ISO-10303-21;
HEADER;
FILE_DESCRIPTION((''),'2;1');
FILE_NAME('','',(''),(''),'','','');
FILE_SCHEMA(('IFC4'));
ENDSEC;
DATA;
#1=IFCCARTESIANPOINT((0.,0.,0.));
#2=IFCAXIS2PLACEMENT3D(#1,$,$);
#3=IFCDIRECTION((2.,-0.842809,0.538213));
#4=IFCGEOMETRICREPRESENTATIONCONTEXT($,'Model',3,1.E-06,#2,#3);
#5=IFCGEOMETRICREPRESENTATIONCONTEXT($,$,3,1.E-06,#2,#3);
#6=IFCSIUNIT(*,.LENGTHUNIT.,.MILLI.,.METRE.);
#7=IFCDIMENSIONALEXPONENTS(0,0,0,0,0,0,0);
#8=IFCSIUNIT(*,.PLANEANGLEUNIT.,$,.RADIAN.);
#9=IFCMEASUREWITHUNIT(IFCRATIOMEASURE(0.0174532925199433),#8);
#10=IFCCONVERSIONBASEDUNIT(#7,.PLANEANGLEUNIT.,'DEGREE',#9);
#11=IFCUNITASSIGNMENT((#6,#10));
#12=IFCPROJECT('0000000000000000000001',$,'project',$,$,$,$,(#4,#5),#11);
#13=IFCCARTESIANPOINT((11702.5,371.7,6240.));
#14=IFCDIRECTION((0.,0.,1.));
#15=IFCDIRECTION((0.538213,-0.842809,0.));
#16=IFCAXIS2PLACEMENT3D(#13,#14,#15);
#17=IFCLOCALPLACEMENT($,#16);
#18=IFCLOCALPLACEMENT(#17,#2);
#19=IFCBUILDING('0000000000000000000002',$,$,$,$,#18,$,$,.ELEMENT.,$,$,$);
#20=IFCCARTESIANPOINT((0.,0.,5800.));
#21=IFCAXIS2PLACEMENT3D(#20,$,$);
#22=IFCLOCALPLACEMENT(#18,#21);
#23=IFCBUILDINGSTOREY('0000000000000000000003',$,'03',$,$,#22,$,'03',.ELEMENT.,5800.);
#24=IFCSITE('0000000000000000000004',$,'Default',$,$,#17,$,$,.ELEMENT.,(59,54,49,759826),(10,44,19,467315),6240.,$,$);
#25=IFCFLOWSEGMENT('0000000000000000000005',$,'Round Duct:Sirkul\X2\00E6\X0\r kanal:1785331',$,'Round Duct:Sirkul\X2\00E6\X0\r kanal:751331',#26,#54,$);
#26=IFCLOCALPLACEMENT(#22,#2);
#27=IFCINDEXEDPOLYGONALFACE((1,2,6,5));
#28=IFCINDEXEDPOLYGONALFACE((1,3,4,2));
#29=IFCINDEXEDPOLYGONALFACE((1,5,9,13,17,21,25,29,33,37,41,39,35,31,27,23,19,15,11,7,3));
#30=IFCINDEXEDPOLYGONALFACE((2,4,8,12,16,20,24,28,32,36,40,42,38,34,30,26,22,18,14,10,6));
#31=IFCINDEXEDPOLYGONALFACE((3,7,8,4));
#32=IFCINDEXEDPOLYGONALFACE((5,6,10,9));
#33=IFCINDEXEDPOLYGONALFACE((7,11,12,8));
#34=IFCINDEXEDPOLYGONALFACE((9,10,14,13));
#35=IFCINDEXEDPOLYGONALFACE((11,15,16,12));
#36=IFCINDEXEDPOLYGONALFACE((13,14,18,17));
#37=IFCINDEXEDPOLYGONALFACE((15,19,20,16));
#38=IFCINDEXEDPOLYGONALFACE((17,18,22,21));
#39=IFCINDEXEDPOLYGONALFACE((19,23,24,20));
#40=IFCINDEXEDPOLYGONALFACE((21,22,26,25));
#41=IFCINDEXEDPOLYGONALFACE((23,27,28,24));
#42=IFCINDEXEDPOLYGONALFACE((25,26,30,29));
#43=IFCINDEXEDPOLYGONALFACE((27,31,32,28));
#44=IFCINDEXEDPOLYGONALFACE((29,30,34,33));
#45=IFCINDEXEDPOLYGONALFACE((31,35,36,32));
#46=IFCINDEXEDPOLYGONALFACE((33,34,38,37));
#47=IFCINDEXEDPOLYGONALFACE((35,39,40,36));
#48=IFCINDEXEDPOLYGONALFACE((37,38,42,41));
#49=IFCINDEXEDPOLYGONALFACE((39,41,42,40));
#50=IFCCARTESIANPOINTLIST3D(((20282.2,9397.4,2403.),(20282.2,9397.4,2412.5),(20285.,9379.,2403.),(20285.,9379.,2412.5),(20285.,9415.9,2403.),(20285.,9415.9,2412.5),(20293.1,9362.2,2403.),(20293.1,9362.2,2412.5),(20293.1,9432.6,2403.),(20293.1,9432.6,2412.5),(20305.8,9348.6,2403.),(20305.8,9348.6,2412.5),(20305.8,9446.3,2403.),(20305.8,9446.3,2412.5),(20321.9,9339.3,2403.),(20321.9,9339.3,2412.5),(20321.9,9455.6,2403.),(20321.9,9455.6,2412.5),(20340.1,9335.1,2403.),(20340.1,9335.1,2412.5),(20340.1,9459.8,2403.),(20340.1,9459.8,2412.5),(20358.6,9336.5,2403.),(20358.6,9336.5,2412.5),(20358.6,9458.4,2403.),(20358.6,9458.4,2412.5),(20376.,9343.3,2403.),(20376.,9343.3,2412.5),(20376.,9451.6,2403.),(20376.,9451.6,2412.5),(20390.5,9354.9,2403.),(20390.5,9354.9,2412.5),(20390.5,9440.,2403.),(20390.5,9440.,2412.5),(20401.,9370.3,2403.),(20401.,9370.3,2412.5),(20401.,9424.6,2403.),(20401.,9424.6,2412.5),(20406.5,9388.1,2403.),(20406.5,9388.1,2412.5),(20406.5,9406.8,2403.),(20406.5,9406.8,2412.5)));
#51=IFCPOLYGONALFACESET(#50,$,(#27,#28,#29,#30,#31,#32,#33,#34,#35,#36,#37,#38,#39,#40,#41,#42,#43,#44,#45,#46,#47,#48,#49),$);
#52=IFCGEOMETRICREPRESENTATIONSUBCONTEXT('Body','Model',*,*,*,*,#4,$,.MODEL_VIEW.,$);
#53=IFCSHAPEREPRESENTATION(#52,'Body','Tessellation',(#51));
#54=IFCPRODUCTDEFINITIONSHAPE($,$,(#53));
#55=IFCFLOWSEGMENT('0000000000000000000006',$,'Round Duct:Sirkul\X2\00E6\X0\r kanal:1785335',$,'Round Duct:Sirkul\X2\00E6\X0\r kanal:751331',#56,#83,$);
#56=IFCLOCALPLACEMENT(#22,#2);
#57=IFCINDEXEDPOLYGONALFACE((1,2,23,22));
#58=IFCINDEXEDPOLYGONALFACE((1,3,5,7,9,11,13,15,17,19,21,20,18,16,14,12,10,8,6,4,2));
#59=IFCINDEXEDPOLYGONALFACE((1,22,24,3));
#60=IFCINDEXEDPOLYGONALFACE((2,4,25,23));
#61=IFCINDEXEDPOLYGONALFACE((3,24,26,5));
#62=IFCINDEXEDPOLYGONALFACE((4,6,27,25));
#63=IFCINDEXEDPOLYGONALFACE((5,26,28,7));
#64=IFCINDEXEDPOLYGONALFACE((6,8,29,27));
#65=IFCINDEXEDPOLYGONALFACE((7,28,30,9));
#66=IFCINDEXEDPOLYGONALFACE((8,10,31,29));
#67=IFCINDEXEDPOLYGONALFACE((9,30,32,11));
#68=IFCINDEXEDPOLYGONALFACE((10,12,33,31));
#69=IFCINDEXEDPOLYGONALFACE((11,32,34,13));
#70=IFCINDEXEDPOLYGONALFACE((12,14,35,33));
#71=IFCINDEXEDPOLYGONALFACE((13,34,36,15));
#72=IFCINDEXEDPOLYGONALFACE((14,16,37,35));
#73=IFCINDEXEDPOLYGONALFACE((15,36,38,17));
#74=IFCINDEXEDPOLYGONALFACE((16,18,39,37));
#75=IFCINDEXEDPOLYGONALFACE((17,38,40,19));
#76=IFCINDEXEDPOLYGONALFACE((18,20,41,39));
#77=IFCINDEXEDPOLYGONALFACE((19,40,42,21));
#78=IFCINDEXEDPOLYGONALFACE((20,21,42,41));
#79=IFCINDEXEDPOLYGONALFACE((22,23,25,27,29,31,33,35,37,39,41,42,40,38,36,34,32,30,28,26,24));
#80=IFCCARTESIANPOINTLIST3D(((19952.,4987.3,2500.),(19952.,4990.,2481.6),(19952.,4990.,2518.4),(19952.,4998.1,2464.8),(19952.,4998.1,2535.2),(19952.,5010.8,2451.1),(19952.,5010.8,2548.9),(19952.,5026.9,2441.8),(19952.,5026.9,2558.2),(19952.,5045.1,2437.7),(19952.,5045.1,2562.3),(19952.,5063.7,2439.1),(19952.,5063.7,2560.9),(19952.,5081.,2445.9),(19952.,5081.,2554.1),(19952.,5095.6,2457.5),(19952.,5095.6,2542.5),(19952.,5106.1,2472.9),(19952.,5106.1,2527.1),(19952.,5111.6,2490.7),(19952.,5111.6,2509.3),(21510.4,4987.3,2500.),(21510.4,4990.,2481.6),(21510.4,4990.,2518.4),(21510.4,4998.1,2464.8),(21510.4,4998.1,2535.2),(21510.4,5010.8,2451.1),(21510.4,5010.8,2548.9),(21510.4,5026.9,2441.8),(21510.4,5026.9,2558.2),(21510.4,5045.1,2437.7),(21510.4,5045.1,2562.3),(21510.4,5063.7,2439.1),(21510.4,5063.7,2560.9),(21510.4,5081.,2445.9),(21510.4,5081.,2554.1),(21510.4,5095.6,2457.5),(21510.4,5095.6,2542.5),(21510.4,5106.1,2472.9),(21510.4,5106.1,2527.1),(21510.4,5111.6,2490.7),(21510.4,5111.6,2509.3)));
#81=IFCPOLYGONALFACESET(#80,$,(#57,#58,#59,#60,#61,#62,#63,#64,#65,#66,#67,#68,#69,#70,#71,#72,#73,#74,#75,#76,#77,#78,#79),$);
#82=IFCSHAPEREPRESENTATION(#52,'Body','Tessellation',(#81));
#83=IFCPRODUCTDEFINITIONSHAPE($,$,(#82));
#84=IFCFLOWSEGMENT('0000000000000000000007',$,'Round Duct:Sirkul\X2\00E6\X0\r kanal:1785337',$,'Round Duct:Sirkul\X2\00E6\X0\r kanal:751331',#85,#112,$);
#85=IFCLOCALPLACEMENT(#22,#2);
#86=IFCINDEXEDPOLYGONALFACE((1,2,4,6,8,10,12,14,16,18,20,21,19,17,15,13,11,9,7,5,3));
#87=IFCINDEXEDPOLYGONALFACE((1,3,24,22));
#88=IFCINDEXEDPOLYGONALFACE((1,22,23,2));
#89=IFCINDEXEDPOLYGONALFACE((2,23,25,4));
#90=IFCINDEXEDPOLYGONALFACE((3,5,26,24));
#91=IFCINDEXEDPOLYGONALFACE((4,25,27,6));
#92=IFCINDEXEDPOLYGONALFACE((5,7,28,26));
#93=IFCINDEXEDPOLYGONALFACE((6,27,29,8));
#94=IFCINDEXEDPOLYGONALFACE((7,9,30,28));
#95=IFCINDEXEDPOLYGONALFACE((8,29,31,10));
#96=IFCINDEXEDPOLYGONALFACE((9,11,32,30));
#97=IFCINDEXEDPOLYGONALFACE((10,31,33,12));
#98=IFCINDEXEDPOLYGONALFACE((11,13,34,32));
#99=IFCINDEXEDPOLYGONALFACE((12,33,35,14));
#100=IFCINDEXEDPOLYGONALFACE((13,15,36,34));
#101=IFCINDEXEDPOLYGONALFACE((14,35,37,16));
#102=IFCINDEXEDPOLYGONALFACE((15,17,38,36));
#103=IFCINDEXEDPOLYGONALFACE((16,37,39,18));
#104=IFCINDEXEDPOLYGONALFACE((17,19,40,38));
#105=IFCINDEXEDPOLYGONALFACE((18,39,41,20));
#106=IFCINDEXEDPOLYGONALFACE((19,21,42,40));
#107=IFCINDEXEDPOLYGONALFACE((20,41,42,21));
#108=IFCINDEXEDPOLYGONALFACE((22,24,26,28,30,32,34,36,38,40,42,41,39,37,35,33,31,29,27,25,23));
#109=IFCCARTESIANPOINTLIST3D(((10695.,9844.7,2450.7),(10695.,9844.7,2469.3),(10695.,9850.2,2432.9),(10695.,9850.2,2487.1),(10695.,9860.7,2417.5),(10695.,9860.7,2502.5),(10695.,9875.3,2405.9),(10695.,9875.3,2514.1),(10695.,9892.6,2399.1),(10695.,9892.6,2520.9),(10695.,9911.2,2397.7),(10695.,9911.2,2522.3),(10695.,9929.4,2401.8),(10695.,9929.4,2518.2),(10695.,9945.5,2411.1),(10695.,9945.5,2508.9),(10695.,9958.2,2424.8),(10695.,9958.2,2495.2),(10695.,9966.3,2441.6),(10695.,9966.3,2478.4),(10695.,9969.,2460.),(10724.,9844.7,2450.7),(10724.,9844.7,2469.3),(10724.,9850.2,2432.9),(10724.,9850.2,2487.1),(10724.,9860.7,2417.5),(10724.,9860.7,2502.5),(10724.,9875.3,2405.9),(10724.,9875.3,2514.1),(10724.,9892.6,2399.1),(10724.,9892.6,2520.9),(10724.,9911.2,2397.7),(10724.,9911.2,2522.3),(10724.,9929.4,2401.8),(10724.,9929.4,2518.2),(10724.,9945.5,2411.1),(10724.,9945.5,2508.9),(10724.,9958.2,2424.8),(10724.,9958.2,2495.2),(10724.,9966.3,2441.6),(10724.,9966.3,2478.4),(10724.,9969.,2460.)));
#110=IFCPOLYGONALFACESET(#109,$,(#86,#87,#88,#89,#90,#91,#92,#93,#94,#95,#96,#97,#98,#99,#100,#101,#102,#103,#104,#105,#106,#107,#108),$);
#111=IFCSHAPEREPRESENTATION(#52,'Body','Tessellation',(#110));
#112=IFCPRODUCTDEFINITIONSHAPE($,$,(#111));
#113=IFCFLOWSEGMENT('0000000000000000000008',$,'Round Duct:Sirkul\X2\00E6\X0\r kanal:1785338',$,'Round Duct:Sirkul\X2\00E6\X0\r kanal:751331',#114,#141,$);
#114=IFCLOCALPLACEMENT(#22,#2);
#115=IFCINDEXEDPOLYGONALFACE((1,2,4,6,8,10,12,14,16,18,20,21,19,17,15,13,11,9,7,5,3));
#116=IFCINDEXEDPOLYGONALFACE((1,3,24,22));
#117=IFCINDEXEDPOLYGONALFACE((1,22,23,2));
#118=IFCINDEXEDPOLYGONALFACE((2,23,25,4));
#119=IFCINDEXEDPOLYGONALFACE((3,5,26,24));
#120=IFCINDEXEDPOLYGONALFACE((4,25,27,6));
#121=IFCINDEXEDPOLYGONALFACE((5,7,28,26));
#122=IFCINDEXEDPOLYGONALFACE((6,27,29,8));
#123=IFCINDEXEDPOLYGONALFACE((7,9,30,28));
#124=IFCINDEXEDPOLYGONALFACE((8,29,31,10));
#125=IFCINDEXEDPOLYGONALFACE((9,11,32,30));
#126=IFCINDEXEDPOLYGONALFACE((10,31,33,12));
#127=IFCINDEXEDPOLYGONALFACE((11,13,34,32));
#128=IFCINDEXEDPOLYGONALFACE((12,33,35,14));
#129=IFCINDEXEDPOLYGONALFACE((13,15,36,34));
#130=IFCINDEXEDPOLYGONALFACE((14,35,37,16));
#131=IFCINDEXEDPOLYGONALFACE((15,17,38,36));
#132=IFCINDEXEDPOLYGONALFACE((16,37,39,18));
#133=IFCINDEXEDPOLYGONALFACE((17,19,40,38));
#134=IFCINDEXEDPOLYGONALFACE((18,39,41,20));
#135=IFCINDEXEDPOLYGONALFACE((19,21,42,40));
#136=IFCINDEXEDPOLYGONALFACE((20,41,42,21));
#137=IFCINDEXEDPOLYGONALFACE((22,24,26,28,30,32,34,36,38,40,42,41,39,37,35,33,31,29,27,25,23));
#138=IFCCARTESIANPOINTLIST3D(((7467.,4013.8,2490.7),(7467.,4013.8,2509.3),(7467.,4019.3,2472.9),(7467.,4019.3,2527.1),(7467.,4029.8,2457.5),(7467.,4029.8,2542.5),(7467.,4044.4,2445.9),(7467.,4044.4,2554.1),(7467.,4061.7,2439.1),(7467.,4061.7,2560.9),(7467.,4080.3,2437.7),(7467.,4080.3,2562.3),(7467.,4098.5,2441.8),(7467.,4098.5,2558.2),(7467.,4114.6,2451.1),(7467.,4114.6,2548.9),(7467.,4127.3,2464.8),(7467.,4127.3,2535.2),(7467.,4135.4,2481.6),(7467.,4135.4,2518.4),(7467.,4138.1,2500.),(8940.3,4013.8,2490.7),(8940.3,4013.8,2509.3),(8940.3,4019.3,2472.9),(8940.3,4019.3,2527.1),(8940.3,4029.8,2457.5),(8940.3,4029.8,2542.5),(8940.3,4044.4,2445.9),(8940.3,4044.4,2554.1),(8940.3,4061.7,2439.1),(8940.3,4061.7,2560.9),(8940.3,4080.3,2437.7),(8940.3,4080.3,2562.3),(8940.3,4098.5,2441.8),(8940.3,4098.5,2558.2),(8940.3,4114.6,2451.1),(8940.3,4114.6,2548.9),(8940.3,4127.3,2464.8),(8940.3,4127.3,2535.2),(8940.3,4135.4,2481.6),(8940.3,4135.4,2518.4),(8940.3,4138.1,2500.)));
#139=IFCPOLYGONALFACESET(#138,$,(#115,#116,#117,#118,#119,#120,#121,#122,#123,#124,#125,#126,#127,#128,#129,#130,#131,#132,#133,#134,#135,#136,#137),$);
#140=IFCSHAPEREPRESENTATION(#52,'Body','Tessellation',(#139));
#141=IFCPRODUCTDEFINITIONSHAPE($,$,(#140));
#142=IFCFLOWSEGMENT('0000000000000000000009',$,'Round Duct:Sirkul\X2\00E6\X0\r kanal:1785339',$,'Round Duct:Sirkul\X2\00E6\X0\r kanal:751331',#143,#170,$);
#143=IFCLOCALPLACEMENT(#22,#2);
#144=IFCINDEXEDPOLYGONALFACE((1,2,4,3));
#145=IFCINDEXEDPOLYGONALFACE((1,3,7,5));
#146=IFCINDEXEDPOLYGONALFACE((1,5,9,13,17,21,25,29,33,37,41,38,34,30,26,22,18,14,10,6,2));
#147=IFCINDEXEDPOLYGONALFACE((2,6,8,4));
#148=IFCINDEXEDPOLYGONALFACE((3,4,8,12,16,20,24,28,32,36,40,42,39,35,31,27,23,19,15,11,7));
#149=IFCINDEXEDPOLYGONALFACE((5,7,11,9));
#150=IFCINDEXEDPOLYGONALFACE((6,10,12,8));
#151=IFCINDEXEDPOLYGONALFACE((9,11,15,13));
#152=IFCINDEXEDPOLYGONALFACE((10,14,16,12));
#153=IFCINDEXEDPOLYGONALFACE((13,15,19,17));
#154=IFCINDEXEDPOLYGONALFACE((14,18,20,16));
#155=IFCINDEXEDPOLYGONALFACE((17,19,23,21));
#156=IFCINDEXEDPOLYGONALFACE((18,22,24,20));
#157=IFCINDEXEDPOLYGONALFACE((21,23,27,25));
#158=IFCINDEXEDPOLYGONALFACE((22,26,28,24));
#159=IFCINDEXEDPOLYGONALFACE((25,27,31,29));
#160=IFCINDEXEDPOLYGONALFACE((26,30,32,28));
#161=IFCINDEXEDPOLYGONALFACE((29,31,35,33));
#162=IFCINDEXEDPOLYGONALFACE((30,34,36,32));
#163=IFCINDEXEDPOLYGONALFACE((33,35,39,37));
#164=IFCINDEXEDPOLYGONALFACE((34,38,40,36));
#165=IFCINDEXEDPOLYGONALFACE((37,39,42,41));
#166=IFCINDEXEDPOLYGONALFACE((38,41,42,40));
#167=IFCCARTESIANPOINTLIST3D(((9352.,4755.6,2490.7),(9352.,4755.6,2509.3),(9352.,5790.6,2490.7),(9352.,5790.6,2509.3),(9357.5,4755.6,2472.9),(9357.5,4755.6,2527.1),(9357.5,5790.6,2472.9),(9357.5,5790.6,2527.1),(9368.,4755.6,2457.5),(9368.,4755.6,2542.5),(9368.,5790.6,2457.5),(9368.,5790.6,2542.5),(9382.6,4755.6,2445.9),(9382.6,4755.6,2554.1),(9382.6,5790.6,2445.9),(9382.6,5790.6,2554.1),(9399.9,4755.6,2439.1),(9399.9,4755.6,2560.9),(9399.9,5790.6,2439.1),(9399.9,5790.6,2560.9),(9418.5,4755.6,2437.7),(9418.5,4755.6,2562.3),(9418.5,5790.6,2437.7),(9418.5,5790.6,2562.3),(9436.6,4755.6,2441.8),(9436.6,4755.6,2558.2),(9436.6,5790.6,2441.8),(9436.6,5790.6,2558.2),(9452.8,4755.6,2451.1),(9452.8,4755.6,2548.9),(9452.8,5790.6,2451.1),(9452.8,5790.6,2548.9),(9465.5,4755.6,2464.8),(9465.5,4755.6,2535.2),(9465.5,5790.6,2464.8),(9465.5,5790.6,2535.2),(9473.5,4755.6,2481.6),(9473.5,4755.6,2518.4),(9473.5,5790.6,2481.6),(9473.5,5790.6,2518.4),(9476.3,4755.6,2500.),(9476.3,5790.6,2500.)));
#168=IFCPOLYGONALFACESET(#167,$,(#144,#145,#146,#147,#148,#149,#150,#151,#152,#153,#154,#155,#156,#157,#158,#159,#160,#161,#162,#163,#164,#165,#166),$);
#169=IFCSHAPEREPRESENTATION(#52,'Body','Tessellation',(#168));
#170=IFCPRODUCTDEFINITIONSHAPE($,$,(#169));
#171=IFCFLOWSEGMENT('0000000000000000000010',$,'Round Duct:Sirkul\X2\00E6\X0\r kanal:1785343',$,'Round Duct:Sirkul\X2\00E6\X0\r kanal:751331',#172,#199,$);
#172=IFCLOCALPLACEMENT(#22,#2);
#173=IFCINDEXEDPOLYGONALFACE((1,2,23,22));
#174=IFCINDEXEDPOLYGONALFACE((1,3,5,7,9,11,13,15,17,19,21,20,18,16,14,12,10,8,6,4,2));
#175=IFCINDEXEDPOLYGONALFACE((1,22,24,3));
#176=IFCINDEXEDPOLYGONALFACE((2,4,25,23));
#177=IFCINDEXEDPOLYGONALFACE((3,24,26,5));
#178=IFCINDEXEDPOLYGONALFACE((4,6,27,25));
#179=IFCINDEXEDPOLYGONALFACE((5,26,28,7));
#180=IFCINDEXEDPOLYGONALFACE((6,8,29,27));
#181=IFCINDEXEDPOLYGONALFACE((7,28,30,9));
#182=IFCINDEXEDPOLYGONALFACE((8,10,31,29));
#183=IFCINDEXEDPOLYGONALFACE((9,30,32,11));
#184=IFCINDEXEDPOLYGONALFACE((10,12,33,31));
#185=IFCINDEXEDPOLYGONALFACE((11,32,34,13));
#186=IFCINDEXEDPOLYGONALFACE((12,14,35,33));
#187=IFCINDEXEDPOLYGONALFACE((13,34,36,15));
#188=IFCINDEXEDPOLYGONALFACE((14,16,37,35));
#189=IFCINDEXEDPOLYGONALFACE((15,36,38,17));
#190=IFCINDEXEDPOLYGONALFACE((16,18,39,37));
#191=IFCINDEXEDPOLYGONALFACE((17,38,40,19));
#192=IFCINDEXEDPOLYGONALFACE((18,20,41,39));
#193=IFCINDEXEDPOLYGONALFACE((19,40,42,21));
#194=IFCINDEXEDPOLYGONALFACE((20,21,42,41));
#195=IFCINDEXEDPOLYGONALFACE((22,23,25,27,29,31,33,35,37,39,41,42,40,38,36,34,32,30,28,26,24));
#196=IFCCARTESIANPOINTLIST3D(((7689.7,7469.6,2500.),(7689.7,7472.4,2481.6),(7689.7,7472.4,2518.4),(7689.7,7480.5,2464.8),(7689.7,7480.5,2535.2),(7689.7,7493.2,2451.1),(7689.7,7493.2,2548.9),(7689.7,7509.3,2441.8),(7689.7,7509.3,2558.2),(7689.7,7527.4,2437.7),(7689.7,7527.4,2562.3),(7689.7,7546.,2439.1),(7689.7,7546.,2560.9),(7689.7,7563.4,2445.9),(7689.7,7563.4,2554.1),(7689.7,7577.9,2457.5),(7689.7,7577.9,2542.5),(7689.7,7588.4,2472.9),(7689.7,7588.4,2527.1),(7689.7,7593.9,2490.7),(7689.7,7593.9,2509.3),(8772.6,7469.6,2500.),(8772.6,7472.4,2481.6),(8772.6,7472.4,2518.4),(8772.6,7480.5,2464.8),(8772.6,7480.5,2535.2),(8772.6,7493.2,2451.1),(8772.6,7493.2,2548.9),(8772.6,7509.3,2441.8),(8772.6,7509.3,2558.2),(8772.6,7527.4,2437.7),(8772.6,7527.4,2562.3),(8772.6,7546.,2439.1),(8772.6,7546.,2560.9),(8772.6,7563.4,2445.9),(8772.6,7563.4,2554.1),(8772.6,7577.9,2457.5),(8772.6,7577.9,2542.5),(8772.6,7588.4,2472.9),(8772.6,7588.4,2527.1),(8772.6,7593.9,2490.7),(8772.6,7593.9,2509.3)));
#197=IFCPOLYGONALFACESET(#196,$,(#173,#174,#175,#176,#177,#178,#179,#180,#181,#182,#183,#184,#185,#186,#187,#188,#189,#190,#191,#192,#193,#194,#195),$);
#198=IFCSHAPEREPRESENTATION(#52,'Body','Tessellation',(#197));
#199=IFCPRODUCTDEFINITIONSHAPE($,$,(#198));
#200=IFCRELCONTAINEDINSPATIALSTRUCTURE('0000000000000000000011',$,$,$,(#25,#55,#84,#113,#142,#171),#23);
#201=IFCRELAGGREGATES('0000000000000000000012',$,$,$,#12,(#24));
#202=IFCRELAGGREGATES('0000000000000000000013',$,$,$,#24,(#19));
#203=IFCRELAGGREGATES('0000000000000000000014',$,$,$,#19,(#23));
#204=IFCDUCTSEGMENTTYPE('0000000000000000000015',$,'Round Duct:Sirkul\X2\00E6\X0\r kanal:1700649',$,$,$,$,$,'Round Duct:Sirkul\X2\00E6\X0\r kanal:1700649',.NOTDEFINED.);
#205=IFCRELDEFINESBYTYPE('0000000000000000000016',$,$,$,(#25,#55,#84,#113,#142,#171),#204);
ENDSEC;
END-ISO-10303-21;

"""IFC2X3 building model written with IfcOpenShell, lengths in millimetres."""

from ifc_helpers import new_model, entity, si_unit, converted_unit, direction, frame, frame_2d, origin, origin_2d_with_axis, place, context, subcontext, project, spatial, circle, extrude, type_object, element, save


model = new_model("IFC2X3")

# Units and contexts
model_context = context("Model", 3, precision=1e-06, world=origin(), true_north=direction((2.0, -0.842809, 0.538213)))
context_of_model = context(None, 3, precision=1e-06, world=origin(), true_north=direction((2.0, -0.842809, 0.538213)))
body_context = subcontext(model_context, "Body", "Model", "MODEL_VIEW")
ifc_project = project(units=[si_unit("LENGTHUNIT", "METRE", prefix="MILLI"), converted_unit("PLANEANGLEUNIT", "DEGREE", entity("IfcRatioMeasure", 0.0174532925199433), si_unit("PLANEANGLEUNIT", "RADIAN"), dimensions=[0, 0, 0, 0, 0, 0, 0])], contexts=[model_context, context_of_model])

# Site, building, storey
site_placement = place(None, frame((11702.5, 371.7, 6240.0), z_axis=(0.0, 0.0, 1.0), x_axis=(0.538213, -0.842809, 0.0)))
site = spatial("IfcSite", under=ifc_project, at=site_placement, Name="Default", CompositionType="ELEMENT", RefLatitude=(59, 54, 49, 759826), RefLongitude=(10, 44, 19, 467315), RefElevation=6240.0)
building_placement = place(site_placement, origin())
building = spatial("IfcBuilding", under=site, at=building_placement, CompositionType="ELEMENT")
storey_placement = place(building_placement, frame((0.0, 0.0, 5800.0)))
storey = spatial("IfcBuildingStorey", under=building, at=storey_placement, Name="03", LongName="03", CompositionType="ELEMENT", Elevation=5800.0)

# Flow segments
duct_segment_type = type_object("IfcDuctSegmentType", Name="Round Duct:Sirkulær kanal:1700649", ElementType="Round Duct:Sirkulær kanal:1700649", PredefinedType="NOTDEFINED")
flow_segment_1_placement = place(storey_placement, origin())
element("IfcFlowSegment", 1, at=flow_segment_1_placement, inside=storey, type_object=duct_segment_type, Name="Round Duct:Sirkulær kanal:1785331", ObjectType="Round Duct:Sirkulær kanal:751331", context=body_context, shape_type="SweptSolid", body=[
    extrude(circle(Radius=62.5, at=origin_2d_with_axis()), frame((20344.7, 9397.4, 2403.0), z_axis=(0.0, 0.0, 1.0), x_axis=(-1.0, 0.0, 0.0)), (0.0, 0.0, 1.0), 9.5),
])
flow_segment_2_placement = place(storey_placement, origin())
element("IfcFlowSegment", 2, at=flow_segment_2_placement, inside=storey, type_object=duct_segment_type, Name="Round Duct:Sirkulær kanal:1785335", ObjectType="Round Duct:Sirkulær kanal:751331", context=body_context, shape_type="SweptSolid", body=[
    extrude(circle(Radius=62.5, at=frame_2d((0.0, 0.0), x_axis=(1.0, 0.0))), frame((19952.0, 5049.8, 2500.0), z_axis=(1.0, 0.0, 0.0), x_axis=(0.0, -1.0, 0.0)), (0.0, 0.0, 1.0), 1558.4),
])
flow_segment_3_placement = place(storey_placement, origin())
element("IfcFlowSegment", 3, at=flow_segment_3_placement, inside=storey, type_object=duct_segment_type, Name="Round Duct:Sirkulær kanal:1785337", ObjectType="Round Duct:Sirkulær kanal:751331", context=body_context, shape_type="SweptSolid", body=[
    extrude(circle(Radius=62.5, at=frame_2d((0.0, 0.0), x_axis=(1.0, 0.0))), frame((10695.0, 9906.5, 2460.0), z_axis=(1.0, 0.0, 0.0), x_axis=(0.0, 1.0, 0.0)), (0.0, 0.0, 1.0), 28.9),
])
flow_segment_4_placement = place(storey_placement, origin())
element("IfcFlowSegment", 4, at=flow_segment_4_placement, inside=storey, type_object=duct_segment_type, Name="Round Duct:Sirkulær kanal:1785338", ObjectType="Round Duct:Sirkulær kanal:751331", context=body_context, shape_type="SweptSolid", body=[
    extrude(circle(Radius=62.5, at=frame_2d((0.0, 0.0), x_axis=(1.0, 0.0))), frame((7467.0, 4075.6, 2500.0), z_axis=(1.0, 0.0, 0.0), x_axis=(0.0, 1.0, 0.0)), (0.0, 0.0, 1.0), 1473.3),
])
flow_segment_5_placement = place(storey_placement, origin())
element("IfcFlowSegment", 5, at=flow_segment_5_placement, inside=storey, type_object=duct_segment_type, Name="Round Duct:Sirkulær kanal:1785339", ObjectType="Round Duct:Sirkulær kanal:751331", context=body_context, shape_type="SweptSolid", body=[
    extrude(circle(Radius=62.5, at=origin_2d_with_axis()), frame((9413.8, 4755.6, 2500.0), z_axis=(0.0, 1.0, 0.0), x_axis=(1.0, 0.0, 0.0)), (0.0, 0.0, 1.0), 1035.0),
])
flow_segment_6_placement = place(storey_placement, origin())
element("IfcFlowSegment", 6, at=flow_segment_6_placement, inside=storey, type_object=duct_segment_type, Name="Round Duct:Sirkulær kanal:1785343", ObjectType="Round Duct:Sirkulær kanal:751331", context=body_context, shape_type="SweptSolid", body=[
    extrude(circle(Radius=62.5, at=frame_2d((0.0, 0.0), x_axis=(1.0, 0.0))), frame((7689.7, 7532.1, 2500.0), z_axis=(1.0, 0.0, 0.0), x_axis=(0.0, -1.0, 0.0)), (0.0, 0.0, 1.0), 1082.9),
])

save(model, "model.ifc")
